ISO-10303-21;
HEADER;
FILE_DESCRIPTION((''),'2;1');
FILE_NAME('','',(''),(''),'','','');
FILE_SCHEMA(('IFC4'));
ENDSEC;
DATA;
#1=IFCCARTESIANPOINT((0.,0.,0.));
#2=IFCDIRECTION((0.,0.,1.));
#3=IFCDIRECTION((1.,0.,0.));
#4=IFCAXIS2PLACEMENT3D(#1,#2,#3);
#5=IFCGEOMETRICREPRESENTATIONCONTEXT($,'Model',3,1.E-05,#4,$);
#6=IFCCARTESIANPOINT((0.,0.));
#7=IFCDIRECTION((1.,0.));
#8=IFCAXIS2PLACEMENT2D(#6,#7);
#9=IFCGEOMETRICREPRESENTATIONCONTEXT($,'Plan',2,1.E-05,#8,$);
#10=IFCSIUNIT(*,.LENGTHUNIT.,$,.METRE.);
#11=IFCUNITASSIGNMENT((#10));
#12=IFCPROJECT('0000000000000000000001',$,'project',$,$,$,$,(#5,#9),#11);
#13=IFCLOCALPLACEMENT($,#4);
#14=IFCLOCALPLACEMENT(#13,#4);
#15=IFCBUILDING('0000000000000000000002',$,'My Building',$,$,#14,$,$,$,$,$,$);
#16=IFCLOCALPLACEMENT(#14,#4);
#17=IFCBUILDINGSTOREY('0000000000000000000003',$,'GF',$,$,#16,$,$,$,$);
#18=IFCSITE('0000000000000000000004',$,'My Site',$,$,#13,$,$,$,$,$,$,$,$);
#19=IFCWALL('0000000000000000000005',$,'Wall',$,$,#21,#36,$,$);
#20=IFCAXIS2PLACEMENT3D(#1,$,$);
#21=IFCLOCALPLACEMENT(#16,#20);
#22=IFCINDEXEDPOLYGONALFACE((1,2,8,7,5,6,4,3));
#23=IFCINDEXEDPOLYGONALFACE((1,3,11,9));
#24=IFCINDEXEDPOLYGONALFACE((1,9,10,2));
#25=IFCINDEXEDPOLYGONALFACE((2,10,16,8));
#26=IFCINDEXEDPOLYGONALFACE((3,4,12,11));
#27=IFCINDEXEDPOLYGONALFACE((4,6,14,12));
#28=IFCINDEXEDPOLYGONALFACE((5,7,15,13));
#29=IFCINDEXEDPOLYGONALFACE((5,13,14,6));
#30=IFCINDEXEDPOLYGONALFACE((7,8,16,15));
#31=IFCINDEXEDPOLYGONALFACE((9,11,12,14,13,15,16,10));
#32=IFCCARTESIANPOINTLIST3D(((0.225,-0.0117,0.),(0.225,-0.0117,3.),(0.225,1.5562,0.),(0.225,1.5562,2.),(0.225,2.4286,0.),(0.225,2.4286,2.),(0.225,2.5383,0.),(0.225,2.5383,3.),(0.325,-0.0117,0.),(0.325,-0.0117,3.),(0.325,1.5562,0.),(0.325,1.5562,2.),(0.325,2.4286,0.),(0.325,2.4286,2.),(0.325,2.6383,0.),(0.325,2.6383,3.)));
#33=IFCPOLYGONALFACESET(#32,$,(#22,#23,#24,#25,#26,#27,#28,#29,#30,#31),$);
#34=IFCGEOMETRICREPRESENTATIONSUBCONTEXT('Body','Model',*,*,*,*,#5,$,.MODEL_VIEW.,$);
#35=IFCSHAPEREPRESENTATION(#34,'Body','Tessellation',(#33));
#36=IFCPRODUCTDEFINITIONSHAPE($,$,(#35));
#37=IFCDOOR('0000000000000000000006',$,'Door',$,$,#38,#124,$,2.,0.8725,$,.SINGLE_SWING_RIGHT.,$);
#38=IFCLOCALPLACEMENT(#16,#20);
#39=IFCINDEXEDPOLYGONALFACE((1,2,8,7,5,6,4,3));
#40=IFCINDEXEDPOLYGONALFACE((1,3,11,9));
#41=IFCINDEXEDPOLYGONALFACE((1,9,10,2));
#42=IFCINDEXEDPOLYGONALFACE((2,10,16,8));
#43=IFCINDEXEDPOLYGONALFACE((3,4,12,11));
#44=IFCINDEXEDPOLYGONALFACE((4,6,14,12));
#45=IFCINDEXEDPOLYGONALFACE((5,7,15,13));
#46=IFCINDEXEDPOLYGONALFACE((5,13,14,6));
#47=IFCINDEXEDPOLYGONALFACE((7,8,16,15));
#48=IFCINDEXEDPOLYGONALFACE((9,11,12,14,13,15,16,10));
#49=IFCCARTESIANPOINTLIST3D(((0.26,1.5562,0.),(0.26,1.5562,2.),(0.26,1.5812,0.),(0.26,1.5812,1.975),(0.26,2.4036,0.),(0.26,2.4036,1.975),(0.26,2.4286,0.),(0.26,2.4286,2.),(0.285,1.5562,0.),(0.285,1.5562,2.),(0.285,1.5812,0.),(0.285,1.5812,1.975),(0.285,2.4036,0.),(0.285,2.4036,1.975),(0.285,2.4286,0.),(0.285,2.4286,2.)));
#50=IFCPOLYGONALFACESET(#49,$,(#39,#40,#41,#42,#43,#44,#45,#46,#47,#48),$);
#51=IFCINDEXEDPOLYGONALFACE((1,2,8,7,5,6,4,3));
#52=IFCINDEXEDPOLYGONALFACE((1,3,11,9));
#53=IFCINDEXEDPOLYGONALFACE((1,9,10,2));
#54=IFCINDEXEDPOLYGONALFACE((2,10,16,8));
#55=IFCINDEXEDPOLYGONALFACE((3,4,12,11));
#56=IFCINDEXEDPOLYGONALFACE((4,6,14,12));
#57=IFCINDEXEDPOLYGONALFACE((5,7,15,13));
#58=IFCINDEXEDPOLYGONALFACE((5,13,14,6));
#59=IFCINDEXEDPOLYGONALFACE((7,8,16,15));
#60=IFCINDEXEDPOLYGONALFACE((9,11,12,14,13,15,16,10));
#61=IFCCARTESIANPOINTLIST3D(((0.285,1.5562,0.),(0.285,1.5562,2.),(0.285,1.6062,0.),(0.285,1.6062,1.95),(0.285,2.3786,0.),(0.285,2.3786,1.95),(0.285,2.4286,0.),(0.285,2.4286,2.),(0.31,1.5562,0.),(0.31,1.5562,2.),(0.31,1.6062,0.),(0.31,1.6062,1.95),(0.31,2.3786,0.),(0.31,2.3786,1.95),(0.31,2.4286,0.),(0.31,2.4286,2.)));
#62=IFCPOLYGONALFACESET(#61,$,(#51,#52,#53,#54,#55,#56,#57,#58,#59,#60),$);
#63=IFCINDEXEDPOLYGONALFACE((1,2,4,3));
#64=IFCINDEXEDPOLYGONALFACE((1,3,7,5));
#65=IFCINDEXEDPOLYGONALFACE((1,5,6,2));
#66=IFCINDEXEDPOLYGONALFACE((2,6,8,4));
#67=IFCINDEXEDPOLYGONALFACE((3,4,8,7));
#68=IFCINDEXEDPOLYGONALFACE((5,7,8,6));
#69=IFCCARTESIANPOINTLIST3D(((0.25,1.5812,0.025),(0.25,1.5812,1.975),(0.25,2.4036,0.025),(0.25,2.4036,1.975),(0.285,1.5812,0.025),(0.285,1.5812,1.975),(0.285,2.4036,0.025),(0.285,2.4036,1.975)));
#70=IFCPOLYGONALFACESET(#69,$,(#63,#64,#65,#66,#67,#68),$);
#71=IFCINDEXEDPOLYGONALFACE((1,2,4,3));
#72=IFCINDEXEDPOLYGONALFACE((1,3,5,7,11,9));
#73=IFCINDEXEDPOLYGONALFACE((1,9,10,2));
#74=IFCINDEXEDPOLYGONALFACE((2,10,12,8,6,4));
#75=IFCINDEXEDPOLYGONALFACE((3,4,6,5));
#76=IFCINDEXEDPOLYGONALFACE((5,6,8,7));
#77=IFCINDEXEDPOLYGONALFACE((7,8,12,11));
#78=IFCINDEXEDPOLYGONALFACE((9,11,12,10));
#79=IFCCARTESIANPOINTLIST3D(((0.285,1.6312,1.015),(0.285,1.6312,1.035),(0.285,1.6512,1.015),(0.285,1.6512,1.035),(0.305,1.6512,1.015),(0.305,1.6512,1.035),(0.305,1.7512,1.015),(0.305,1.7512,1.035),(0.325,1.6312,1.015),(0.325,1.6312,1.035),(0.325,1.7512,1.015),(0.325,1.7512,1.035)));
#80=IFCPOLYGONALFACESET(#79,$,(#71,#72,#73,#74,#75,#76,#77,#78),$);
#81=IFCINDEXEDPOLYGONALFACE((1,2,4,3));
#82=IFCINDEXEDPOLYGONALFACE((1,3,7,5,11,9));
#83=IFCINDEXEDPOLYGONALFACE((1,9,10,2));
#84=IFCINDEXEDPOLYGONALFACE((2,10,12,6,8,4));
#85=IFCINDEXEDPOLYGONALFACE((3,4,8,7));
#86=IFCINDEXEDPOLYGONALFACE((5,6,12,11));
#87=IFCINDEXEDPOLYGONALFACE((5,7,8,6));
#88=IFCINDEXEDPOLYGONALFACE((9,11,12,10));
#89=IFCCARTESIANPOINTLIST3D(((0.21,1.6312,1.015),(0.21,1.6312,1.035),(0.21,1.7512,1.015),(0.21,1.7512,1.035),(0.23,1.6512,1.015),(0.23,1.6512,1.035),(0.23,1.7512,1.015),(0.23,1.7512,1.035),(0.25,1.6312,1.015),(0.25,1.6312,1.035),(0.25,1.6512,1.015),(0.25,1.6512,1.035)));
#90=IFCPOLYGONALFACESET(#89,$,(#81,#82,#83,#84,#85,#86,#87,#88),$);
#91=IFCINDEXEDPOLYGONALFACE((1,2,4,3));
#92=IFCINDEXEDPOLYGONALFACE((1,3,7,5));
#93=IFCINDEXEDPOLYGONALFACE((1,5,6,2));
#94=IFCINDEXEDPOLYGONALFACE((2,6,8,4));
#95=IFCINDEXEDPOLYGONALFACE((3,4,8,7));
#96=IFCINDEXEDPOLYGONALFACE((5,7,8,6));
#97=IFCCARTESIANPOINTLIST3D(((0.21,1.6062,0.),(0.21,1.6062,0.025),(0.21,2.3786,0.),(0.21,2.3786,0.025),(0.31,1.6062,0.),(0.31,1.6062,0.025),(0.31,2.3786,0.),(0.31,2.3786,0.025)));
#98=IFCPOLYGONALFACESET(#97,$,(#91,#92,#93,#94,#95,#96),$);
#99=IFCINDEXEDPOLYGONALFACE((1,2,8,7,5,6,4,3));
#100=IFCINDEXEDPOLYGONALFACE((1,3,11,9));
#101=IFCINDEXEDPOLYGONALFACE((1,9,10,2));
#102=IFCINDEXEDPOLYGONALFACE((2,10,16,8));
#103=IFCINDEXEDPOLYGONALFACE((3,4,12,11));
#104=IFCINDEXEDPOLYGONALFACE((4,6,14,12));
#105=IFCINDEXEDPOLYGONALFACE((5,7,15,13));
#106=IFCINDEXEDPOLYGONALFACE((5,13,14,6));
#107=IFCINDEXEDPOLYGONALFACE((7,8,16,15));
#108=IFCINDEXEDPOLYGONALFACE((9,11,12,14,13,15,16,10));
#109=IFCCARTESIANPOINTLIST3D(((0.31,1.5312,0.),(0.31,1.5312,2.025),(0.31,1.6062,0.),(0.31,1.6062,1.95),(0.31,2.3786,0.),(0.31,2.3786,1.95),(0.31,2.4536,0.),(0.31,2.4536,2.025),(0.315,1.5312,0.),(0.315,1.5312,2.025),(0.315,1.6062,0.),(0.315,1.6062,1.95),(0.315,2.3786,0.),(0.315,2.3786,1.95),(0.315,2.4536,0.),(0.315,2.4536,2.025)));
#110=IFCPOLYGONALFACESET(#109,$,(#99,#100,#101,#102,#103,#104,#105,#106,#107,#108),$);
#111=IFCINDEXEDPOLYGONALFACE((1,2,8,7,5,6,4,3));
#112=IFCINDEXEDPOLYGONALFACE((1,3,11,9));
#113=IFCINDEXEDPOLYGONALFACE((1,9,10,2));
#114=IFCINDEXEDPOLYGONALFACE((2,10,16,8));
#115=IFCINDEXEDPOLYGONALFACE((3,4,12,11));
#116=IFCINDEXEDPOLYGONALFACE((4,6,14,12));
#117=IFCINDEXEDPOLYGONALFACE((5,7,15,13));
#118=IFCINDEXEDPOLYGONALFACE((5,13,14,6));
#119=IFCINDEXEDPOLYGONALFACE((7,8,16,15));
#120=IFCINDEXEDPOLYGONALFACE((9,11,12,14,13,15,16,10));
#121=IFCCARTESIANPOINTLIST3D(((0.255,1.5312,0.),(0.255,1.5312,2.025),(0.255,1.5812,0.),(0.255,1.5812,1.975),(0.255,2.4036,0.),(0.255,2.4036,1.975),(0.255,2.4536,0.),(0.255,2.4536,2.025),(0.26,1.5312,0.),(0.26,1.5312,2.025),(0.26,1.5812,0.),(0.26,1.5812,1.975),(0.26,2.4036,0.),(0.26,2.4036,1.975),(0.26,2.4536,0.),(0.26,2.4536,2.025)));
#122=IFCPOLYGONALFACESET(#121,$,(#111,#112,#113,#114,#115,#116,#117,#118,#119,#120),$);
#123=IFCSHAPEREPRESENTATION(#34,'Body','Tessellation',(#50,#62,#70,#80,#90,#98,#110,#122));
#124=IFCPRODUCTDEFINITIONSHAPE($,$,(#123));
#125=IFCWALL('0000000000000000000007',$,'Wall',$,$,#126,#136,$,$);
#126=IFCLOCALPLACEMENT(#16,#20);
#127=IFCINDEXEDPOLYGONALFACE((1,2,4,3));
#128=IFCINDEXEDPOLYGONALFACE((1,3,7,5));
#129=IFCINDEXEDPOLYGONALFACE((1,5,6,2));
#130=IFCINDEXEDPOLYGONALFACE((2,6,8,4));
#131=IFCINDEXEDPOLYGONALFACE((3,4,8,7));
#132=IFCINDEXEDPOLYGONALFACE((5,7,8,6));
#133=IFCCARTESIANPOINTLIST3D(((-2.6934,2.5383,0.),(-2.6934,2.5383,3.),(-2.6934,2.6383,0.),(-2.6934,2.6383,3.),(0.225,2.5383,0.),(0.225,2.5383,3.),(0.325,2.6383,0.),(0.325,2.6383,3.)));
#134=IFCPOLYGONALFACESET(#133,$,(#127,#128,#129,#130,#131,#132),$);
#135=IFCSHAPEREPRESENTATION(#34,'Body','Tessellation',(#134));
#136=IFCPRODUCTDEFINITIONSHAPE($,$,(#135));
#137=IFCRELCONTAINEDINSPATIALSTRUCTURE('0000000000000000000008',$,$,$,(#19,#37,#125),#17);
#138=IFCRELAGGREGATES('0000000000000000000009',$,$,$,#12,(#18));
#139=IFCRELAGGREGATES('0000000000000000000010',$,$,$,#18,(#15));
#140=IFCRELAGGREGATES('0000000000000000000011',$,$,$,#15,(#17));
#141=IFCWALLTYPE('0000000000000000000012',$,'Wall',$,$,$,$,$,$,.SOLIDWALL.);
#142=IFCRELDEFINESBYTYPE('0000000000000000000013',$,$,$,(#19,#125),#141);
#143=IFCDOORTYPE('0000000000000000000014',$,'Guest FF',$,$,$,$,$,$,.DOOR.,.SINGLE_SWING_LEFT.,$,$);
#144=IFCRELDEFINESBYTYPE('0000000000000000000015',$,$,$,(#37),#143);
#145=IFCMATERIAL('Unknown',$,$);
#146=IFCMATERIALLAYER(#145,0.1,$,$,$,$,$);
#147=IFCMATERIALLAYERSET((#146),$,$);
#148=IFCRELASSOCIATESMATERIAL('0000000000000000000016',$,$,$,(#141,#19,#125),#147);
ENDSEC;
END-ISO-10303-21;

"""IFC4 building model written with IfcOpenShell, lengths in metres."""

from ifc_helpers import new_model, entity, si_unit, frame, origin_with_axes, origin_2d_with_axis, place, context, subcontext, project, spatial, line, indexed_curve, outline, extrude, shape, source, transform, mapped, material, layer, layer_set, layer_usage, type_object, type_shapes, element, fill, save


model = new_model("IFC4")

# Units and contexts
model_context = context("Model", 3, precision=1e-05, world=origin_with_axes())
plan_context = context("Plan", 2, precision=1e-05, world=origin_2d_with_axis())
body_context_1 = subcontext(model_context, "Body", "Model", "MODEL_VIEW")
body_context_2 = subcontext(plan_context, "Body", "Plan", "PLAN_VIEW")
ifc_project = project(units=[si_unit("LENGTHUNIT", "METRE")], contexts=[model_context, plan_context])

# Site, building, storey
site_placement = place(None, origin_with_axes())
site = spatial("IfcSite", under=ifc_project, at=site_placement, Name="My Site")
building_placement = place(site_placement, origin_with_axes())
building = spatial("IfcBuilding", under=site, at=building_placement, Name="My Building")
storey_placement = place(building_placement, origin_with_axes())
storey = spatial("IfcBuildingStorey", under=building, at=storey_placement, Name="GF")

# Shared definitions
ifc_material = material(Name="Unknown")

# Shared definitions
ifc_layer_1 = layer(ifc_material, 0.1)
ifc_layer_set_1 = layer_set([ifc_layer_1])
wall_type = type_object("IfcWallType", Name="Wall", PredefinedType="SOLIDWALL", material=ifc_layer_set_1)

# Wall, opening, door
ifc_layer_usage_1 = layer_usage(ifc_layer_set_1, "AXIS2", "POSITIVE", 0.0)
wall_1_placement = place(storey_placement, frame((0.325, -0.0117, 0.0), z_axis=(0.0, 0.0, 1.0), x_axis=(0.0, 1.0, 0.0)))
wall_1 = element("IfcWall", 1, at=wall_1_placement, inside=storey, type_object=wall_type, material=ifc_layer_usage_1, Name="Wall", context=body_context_1, shape_type="SweptSolid", body=[
    extrude(outline(indexed_curve([(0.0, 0.0), (0.0, 0.1), (2.55, 0.1), (2.65, 0.0)], segments=[line(1, 2, 3, 4, 1)])), origin_with_axes(), (0.0, 0.0, 1.0), 3.0),
])
shared_shape_1 = source(origin_with_axes(), body_context_1, "Body", "SweptSolid", [
    extrude(outline(indexed_curve([(0.0, 0.0), (0.8725, 0.0), (0.8725, 2.0), (0.0, 2.0)], segments=[line(1, 2, 3, 4, 1)])), frame((0.0, -0.6, 0.0), z_axis=(0.0, -1.0, 0.0), x_axis=(1.0, 0.0, 0.0)), (0.0, 0.0, -1.0), 1.2),
])
opening_1_placement = place(wall_1_placement, frame((1.5679, 0.015, 0.0), z_axis=(0.0, 0.0, 1.0), x_axis=(1.0, 0.0, 0.0)))
opening_1 = element("IfcOpeningElement", 2, at=opening_1_placement, cuts=wall_1, PredefinedType="OPENING", context=body_context_1, shape_type="MappedRepresentation", body=[
    mapped(shared_shape_1, transform((0.0, 0.0, 0.0), x_axis=(1.0, 0.0, 0.0), y_axis=(0.0, 1.0, 0.0), z_axis=(0.0, 0.0, 1.0), scale=1.0)),
])
door_type_1 = type_object("IfcDoorType", Name="Guest FF", OperationType="SINGLE_SWING_LEFT", PredefinedType="DOOR")
shared_shape_2 = source(origin_with_axes(), body_context_1, "Body", "SweptSolid", [
    extrude(outline(indexed_curve([(0.0, 0.0), (0.0, 2.0), (0.8725, 2.0), (0.8725, 0.0), (0.8475, 0.0), (0.8475, 1.975), (0.025, 1.975), (0.025, 0.0)], segments=[line(1, 2, 3, 4, 5, 6, 7, 8, 1)])), frame((0.0, 0.025, 0.0), z_axis=(0.0, -1.0, 0.0), x_axis=(1.0, 0.0, 0.0)), (0.0, 0.0, -1.0), 0.025),
    extrude(outline(indexed_curve([(0.0, 0.0), (0.0, 2.0), (0.8725, 2.0), (0.8725, 0.0), (0.8225, 0.0), (0.8225, 1.95), (0.05, 1.95), (0.05, 0.0)], segments=[line(1, 2, 3, 4, 5, 6, 7, 8, 1)])), frame((0.0, 0.0, 0.0), z_axis=(0.0, -1.0, 0.0), x_axis=(1.0, 0.0, 0.0)), (0.0, 0.0, -1.0), 0.025),
    extrude(outline(indexed_curve([(0.0, 0.0), (0.8225, 0.0), (0.8225, 0.035), (0.0, 0.035)], segments=[line(1, 2, 3, 4, 1)])), frame((0.025, 0.025, 0.025), z_axis=(0.0, 0.0, 1.0), x_axis=(1.0, 0.0, 0.0)), (0.0, 0.0, 1.0), 1.95),
    extrude(outline(indexed_curve([(0.0, 0.0), (0.0, -0.04), (0.12, -0.04), (0.12, -0.02), (0.02, -0.02), (0.02, 0.0)], segments=[line(1, 2, 3, 4, 5, 6, 1)])), frame((0.075, 0.025, 1.015), z_axis=(0.0, 0.0, 1.0), x_axis=(1.0, 0.0, 0.0)), (0.0, 0.0, 1.0), 0.02),
    extrude(outline(indexed_curve([(0.0, 0.0), (0.0, 0.04), (0.12, 0.04), (0.12, 0.02), (0.02, 0.02), (0.02, 0.0)], segments=[line(1, 2, 3, 4, 5, 6, 1)])), frame((0.075, 0.06, 1.015), z_axis=(0.0, 0.0, 1.0), x_axis=(1.0, 0.0, 0.0)), (0.0, 0.0, 1.0), 0.02),
    extrude(outline(indexed_curve([(0.0, 0.0), (0.7725, 0.0), (0.7725, 0.1), (0.0, 0.1)], segments=[line(1, 2, 3, 4, 1)])), frame((0.05, 0.0, 0.0), z_axis=(0.0, 0.0, 1.0), x_axis=(1.0, 0.0, 0.0)), (0.0, 0.0, 1.0), 0.025),
    extrude(outline(indexed_curve([(0.0, 0.0), (0.0, 2.025), (0.9225, 2.025), (0.9225, 0.0), (0.8475, 0.0), (0.8475, 1.95), (0.075, 1.95), (0.075, 0.0)], segments=[line(1, 2, 3, 4, 5, 6, 7, 8, 1)])), frame((-0.025, -0.005, 0.0), z_axis=(0.0, -1.0, 0.0), x_axis=(1.0, 0.0, 0.0)), (0.0, 0.0, -1.0), 0.005),
    extrude(outline(indexed_curve([(0.0, 0.0), (0.0, 2.025), (0.9225, 2.025), (0.9225, 0.0), (0.8725, 0.0), (0.8725, 1.975), (0.05, 1.975), (0.05, 0.0)], segments=[line(1, 2, 3, 4, 5, 6, 7, 8, 1)])), frame((-0.025, 0.05, 0.0), z_axis=(0.0, -1.0, 0.0), x_axis=(1.0, 0.0, 0.0)), (0.0, 0.0, -1.0), 0.005),
])
shared_shape_3 = source(origin_with_axes(), body_context_2, "Body", "Curve2D", [
    entity("IfcIndexedPolyCurve", entity("IfcCartesianPointList2D", [[0.0, 0.0], [0.0, 0.05], [0.025, 0.05], [0.025, 0.025], [0.05, 0.025], [0.05, 0.0]]), [entity("IfcLineIndex", [1, 2, 3, 4, 5, 6, 1])]),
    entity("IfcIndexedPolyCurve", entity("IfcCartesianPointList2D", [[0.8725, 0.0], [0.8725, 0.05], [0.8475, 0.05], [0.8475, 0.025], [0.8225, 0.025], [0.8225, 0.0]]), [entity("IfcLineIndex", [1, 2, 3, 4, 5, 6, 1])]),
    entity("IfcTrimmedCurve", entity("IfcEllipse", entity("IfcAxis2Placement2D", entity("IfcCartesianPoint", [0.8125, 0.05]), entity("IfcDirection", [1.0, 0.0])), 0.7875, 0.8225), [entity("IfcCartesianPoint", [0.8125, 0.8725])], [entity("IfcCartesianPoint", [0.025, 0.05])], True, "CARTESIAN"),
    entity("IfcIndexedPolyCurve", entity("IfcCartesianPointList2D", [[0.8475, 0.05], [0.8125, 0.05], [0.8125, 0.8725], [0.8475, 0.8725]]), [entity("IfcLineIndex", [1, 2, 3, 4, 1])]),
])
type_shapes(door_type_1, [shared_shape_2, shared_shape_3])
door_1_placement = place(opening_1_placement, frame((0.0, 0.0, 0.0), z_axis=(0.0, 0.0, 1.0), x_axis=(1.0, 0.0, 0.0)))
door_1 = element("IfcDoor", 3, at=door_1_placement, inside=storey, type_object=door_type_1, Name="Door", OperationType="SINGLE_SWING_RIGHT", OverallHeight=2.0, OverallWidth=0.8725, shapes=[
    shape(body_context_1, "Body", "MappedRepresentation", [mapped(shared_shape_2, transform((0.0, 0.0, 0.0), x_axis=(1.0, 0.0, 0.0), y_axis=(0.0, 1.0, 0.0), z_axis=(0.0, 0.0, 1.0), scale=1.0))]),
    shape(body_context_2, "Body", "MappedRepresentation", [mapped(shared_shape_3, transform((0.0, 0.0, 0.0), x_axis=(1.0, 0.0, 0.0), y_axis=(0.0, 1.0, 0.0), z_axis=(0.0, 0.0, 1.0), scale=1.0))]),
])
fill(opening_1, door_1)

# Wall
ifc_layer_usage_2 = layer_usage(ifc_layer_set_1, "AXIS2", "POSITIVE", 0.0)
wall_2_placement = place(storey_placement, frame((0.325, 2.6383, 0.0), z_axis=(0.0, 0.0, 1.0), x_axis=(-1.0, 0.0, 0.0)))
element("IfcWall", 4, at=wall_2_placement, inside=storey, type_object=wall_type, material=ifc_layer_usage_2, Name="Wall", context=body_context_1, shape_type="SweptSolid", body=[
    extrude(outline(indexed_curve([(0.0, 0.0), (0.1, 0.1), (3.0184, 0.1), (3.0184, 0.0)], segments=[line(1, 2, 3, 4, 1)])), origin_with_axes(), (0.0, 0.0, 1.0), 3.0),
])

save(model, "model.ifc")
